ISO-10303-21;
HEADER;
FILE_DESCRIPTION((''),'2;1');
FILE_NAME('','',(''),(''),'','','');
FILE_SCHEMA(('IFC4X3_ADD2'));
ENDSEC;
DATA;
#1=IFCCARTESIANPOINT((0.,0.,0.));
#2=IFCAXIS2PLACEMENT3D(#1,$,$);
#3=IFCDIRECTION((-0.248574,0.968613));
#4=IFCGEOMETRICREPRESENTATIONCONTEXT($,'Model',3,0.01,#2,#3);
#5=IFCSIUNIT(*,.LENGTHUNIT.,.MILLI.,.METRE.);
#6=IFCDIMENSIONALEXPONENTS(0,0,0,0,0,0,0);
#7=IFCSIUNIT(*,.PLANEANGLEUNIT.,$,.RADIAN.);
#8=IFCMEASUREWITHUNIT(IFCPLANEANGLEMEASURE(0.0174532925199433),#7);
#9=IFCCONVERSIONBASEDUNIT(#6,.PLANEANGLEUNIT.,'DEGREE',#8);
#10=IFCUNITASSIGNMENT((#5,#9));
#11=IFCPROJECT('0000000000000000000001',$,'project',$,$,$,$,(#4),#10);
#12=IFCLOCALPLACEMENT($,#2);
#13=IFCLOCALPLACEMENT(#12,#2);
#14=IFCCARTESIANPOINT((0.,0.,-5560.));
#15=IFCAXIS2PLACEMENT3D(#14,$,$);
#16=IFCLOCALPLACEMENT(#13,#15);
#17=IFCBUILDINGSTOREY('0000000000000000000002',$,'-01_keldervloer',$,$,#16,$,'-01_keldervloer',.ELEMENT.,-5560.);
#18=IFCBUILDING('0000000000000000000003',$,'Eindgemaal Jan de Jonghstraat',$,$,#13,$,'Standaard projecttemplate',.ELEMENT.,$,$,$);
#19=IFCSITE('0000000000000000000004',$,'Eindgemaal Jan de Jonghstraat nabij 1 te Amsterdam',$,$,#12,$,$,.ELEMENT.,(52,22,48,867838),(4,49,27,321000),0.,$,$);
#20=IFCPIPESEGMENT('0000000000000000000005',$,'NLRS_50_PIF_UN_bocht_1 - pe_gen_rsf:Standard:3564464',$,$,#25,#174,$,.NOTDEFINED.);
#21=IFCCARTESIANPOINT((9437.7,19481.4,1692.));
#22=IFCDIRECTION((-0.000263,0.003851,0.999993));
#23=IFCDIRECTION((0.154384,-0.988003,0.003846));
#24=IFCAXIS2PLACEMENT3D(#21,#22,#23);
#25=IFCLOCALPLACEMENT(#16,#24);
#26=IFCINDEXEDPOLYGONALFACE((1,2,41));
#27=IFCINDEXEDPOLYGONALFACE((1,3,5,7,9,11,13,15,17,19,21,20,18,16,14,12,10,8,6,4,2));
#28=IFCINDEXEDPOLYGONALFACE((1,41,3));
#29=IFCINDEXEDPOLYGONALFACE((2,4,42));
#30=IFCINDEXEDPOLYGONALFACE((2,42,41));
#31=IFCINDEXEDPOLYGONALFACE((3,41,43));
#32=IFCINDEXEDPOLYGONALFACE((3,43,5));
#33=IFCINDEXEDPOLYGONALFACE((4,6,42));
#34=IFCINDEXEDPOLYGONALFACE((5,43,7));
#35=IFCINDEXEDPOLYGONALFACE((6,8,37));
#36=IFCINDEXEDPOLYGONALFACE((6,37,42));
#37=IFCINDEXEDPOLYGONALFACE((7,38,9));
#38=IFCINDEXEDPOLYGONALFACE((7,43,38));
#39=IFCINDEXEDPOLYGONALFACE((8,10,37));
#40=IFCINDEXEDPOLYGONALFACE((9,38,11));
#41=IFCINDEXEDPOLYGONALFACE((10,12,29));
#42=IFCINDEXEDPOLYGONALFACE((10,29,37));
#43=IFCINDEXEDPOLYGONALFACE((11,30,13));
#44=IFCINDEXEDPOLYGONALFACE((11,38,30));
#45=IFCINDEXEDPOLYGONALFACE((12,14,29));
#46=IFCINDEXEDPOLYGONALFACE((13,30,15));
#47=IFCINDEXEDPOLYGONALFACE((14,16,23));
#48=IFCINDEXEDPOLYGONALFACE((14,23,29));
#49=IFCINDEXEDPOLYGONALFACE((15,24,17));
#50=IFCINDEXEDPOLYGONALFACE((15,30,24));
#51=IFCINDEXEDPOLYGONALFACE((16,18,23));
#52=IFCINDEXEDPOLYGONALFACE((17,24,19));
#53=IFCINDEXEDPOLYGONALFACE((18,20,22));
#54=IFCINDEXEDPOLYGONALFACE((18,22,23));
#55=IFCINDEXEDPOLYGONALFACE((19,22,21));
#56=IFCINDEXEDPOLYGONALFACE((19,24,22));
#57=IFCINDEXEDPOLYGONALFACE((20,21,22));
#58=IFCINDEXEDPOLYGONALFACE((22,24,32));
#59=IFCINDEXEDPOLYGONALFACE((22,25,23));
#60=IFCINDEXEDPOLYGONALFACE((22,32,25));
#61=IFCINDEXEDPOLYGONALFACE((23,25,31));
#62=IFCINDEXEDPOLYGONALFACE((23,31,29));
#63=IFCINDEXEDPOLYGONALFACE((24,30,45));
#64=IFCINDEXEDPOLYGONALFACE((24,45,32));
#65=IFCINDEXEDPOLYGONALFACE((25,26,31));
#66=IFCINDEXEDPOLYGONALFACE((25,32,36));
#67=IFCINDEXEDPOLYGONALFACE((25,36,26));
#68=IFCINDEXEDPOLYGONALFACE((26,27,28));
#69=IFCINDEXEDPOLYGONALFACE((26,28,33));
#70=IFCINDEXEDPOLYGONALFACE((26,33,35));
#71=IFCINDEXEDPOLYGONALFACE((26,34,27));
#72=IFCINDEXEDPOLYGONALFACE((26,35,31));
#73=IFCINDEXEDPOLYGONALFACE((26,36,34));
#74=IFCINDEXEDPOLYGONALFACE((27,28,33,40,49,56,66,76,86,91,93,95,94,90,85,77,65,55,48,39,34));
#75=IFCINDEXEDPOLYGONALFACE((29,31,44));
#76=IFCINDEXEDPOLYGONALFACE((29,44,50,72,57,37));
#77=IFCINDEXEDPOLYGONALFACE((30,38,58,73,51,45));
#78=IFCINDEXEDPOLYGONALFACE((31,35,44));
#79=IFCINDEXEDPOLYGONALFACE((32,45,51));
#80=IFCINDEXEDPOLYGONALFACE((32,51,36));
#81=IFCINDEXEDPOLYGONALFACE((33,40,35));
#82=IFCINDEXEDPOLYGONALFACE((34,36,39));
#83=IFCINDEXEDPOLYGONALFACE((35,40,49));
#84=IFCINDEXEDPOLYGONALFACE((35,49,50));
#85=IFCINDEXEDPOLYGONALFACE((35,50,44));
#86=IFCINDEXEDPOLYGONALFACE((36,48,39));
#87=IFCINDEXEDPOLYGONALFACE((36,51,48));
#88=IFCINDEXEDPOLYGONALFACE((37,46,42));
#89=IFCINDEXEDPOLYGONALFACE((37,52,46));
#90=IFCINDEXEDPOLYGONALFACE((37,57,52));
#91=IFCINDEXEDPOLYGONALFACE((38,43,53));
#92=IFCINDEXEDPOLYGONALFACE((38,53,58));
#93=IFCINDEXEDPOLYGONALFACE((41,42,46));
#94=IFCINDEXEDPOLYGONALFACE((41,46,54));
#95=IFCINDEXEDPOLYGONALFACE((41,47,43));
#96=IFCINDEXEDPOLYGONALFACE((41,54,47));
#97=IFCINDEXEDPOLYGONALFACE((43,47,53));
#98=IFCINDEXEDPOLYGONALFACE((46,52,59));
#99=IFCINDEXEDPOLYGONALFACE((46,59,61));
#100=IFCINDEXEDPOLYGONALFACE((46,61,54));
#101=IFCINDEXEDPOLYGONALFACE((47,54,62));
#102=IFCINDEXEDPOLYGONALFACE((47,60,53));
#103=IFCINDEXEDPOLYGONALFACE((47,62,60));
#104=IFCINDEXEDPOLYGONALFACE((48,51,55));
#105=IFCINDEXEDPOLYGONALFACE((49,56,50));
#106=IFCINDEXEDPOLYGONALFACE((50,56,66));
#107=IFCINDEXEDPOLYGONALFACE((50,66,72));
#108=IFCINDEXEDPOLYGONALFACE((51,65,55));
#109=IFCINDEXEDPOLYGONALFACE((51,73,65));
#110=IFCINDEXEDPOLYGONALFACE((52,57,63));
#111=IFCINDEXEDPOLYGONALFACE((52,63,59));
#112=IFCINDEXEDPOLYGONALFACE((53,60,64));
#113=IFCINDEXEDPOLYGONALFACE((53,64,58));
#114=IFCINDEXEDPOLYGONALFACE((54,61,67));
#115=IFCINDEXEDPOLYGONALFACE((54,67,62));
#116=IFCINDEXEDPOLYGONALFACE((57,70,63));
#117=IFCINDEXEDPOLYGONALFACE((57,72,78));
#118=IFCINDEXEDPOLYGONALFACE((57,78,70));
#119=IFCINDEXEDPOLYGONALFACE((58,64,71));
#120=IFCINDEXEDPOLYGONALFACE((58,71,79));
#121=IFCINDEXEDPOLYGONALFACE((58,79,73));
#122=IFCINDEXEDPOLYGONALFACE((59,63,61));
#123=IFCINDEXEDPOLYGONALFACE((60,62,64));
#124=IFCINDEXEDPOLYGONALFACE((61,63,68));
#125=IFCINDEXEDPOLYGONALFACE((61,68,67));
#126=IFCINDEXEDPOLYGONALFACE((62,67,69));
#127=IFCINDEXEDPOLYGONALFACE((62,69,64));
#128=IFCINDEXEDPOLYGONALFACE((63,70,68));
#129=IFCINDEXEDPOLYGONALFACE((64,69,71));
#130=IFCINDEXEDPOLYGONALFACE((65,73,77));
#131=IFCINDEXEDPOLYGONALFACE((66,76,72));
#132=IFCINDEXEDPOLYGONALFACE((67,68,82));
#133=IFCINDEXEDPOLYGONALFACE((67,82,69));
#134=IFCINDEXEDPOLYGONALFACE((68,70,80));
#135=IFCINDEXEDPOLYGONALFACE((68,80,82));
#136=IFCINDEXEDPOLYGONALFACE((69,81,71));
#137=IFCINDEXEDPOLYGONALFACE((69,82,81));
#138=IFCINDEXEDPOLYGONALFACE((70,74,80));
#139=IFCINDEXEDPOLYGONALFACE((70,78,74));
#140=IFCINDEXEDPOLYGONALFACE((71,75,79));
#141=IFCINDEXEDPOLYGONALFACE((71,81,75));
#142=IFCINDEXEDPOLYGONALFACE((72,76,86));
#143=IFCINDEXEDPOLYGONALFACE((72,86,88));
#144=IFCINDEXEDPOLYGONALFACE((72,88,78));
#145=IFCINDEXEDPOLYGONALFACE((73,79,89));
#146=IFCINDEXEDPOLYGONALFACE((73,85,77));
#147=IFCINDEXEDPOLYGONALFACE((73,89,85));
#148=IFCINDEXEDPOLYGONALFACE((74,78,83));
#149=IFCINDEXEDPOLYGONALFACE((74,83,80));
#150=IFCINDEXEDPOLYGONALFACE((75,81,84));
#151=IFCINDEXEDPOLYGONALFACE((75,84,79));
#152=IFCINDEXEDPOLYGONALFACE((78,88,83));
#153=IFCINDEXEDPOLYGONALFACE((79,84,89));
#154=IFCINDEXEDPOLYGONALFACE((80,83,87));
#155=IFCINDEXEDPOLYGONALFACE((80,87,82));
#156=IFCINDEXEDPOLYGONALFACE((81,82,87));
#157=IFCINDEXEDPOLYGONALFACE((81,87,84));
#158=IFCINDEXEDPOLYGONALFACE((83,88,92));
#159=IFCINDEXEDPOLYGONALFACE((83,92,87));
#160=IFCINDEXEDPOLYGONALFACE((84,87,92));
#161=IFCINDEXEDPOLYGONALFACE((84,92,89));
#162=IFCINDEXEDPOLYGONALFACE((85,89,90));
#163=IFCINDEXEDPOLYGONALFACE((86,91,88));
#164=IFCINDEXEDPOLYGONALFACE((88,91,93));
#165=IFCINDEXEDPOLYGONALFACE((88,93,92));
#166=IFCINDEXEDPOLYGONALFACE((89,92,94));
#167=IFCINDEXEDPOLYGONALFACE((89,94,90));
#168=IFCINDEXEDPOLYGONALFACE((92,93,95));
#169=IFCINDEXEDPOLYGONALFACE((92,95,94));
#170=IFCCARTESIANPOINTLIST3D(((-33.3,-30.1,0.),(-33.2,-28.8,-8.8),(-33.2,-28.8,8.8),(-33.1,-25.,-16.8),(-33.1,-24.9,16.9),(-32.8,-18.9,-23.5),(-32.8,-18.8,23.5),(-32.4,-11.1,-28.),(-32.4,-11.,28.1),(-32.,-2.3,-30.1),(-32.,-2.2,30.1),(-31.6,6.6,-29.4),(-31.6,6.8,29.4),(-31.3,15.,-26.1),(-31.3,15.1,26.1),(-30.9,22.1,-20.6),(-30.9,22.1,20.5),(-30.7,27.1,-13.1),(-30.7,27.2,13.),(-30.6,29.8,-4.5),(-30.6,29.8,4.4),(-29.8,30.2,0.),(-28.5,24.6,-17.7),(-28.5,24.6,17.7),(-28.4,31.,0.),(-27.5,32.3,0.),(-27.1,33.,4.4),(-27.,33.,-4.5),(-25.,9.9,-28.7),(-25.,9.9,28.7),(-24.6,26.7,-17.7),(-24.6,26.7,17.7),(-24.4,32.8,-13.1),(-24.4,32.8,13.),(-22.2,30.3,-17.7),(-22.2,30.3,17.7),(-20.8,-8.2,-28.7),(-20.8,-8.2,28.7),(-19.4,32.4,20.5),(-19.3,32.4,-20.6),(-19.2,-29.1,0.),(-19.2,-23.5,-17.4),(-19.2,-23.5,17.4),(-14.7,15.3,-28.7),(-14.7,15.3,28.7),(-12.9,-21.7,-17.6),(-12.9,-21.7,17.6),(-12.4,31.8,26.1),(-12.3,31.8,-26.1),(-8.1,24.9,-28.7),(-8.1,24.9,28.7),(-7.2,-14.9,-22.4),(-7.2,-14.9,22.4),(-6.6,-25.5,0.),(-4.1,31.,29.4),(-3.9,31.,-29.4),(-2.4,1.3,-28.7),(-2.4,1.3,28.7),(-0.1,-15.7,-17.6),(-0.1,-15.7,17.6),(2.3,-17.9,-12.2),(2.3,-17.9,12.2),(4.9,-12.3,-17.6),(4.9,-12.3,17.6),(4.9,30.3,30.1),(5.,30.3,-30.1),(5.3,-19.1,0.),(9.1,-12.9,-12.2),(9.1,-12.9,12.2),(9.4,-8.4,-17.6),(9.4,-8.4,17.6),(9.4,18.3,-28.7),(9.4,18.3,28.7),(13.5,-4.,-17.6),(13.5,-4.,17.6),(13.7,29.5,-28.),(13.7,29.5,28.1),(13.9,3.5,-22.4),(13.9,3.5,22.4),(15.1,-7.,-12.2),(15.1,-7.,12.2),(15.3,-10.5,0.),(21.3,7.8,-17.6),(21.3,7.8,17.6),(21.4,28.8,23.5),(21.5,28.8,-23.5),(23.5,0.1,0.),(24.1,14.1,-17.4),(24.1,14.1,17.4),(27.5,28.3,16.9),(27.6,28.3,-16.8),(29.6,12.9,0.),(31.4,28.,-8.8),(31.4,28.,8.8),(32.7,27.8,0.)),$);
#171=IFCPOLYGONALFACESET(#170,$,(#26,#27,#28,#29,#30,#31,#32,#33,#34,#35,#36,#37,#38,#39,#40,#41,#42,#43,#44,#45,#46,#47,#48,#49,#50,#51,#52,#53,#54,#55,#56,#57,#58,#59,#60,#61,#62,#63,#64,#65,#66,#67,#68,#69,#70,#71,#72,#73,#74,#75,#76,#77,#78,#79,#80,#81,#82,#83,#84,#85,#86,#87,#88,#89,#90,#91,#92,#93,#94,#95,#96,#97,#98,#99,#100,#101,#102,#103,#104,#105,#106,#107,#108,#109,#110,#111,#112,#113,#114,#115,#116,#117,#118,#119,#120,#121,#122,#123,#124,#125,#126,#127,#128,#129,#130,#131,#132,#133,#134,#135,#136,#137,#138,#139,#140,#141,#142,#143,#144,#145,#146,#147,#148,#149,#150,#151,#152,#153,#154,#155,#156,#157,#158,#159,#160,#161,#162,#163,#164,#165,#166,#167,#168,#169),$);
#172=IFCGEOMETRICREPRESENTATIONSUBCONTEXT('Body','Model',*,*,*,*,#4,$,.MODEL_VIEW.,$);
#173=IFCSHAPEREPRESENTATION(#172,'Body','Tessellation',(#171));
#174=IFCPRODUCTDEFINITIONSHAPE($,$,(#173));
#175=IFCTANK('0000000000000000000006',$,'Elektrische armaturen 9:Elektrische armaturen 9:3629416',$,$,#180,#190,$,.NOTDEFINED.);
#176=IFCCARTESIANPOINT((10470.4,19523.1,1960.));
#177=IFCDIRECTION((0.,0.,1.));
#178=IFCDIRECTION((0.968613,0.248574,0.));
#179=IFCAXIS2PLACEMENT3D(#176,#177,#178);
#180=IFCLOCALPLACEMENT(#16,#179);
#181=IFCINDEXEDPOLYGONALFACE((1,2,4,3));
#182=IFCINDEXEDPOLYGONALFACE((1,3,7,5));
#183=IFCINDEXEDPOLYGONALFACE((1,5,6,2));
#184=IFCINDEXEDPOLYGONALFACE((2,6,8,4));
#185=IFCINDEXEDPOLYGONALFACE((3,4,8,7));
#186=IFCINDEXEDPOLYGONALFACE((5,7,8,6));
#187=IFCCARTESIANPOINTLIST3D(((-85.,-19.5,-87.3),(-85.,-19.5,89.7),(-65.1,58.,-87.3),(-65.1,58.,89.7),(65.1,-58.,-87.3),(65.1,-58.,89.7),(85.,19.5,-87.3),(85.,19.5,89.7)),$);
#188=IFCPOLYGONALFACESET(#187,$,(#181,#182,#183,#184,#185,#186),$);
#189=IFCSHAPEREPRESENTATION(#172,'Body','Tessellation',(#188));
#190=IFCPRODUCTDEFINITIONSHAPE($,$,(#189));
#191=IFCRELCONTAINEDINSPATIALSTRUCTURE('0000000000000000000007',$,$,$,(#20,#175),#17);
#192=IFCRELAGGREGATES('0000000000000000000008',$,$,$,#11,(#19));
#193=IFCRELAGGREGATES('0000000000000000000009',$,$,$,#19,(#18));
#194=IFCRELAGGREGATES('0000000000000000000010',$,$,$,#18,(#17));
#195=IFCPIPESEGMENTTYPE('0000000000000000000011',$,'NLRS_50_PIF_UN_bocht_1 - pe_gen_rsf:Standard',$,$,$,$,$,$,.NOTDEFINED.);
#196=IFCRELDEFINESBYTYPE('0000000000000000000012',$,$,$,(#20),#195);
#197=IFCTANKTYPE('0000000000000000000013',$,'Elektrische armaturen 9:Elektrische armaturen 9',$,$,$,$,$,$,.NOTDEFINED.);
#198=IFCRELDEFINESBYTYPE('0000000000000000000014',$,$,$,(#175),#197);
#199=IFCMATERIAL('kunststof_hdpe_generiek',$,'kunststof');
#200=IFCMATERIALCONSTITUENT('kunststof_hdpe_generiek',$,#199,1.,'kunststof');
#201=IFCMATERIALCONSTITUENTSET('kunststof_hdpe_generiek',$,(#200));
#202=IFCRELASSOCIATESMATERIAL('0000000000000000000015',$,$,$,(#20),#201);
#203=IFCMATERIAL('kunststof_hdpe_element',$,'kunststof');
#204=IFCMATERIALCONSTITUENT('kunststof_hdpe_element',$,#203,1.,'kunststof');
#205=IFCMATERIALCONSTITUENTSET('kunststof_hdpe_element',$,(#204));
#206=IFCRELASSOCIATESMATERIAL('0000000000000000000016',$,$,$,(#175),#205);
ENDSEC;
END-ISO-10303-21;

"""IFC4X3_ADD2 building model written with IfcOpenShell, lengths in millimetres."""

from ifc_helpers import new_model, entity, si_unit, converted_unit, direction, frame, origin, origin_2d_with_axis, place, context, subcontext, project, spatial, rectangle, extrude, source, transform, mapped, material, constituent, constituent_set, type_object, type_shapes, element, save


model = new_model("IFC4X3_ADD2")

# Units and contexts
model_context = context("Model", 3, precision=0.01, world=origin(), true_north=direction((-0.248574, 0.968613)))
body_context = subcontext(model_context, "Body", "Model", "MODEL_VIEW")
ifc_project = project(units=[si_unit("LENGTHUNIT", "METRE", prefix="MILLI"), converted_unit("PLANEANGLEUNIT", "DEGREE", entity("IfcPlaneAngleMeasure", 0.0174532925199433), si_unit("PLANEANGLEUNIT", "RADIAN"), dimensions=[0, 0, 0, 0, 0, 0, 0])], contexts=[model_context])

# Site, building, storey
site_placement = place(None, origin())
site = spatial("IfcSite", under=ifc_project, at=site_placement, Name="Eindgemaal Jan de Jonghstraat nabij 1 te Amsterdam", CompositionType="ELEMENT", RefLatitude=(52, 22, 48, 867838), RefLongitude=(4, 49, 27, 321000), RefElevation=0.0)
building_placement = place(site_placement, origin())
building = spatial("IfcBuilding", under=site, at=building_placement, Name="Eindgemaal Jan de Jonghstraat", LongName="Standaard projecttemplate", CompositionType="ELEMENT")
storey_placement = place(building_placement, frame((0.0, 0.0, -5560.0)))
storey = spatial("IfcBuildingStorey", under=building, at=storey_placement, Name="-01_keldervloer", LongName="-01_keldervloer", CompositionType="ELEMENT", Elevation=-5560.0)

# Pipe segment
ifc_material_1 = material(Name="kunststof_hdpe_generiek", Category="kunststof")
ifc_constituent_1 = constituent(ifc_material_1, Name="kunststof_hdpe_generiek", Category="kunststof", fraction=1.0)
ifc_constituent_set_1 = constituent_set(constituents=[ifc_constituent_1], Name="kunststof_hdpe_generiek")
pipe_segment_type_1 = type_object("IfcPipeSegmentType", Name="NLRS_50_PIF_UN_bocht_1 - pe_gen_rsf:Standard", PredefinedType="NOTDEFINED")
trimmed_curve_1 = entity("IfcTrimmedCurve", entity("IfcCircle", entity("IfcAxis2Placement2D", entity("IfcCartesianPoint", [-3.2, 0.0]), entity("IfcDirection", [0.08671, 0.996234])), 3.2), [entity("IfcParameterValue", 274.974347)], [entity("IfcParameterValue", 0.0)], True, "PARAMETER")
shared_shape_1 = source(origin(), body_context, "Body", "AdvancedSweptSolid", [
    entity("IfcSurfaceCurveSweptAreaSolid", entity("IfcCircleProfileDef", "AREA", None, entity("IfcAxis2Placement2D", entity("IfcCartesianPoint", [30.1, 0.0]), entity("IfcDirection", [1.0, 0.0])), 30.1), entity("IfcAxis2Placement3D", entity("IfcCartesianPoint", [-27.4, 33.1, 0.0]), entity("IfcDirection", [0.0, 0.0, -1.0]), entity("IfcDirection", [0.996234, -0.08671, 0.0])), trimmed_curve_1, entity("IfcParameterValue", 0.0), entity("IfcParameterValue", 85.025653), entity("IfcSurfaceOfLinearExtrusion", entity("IfcArbitraryOpenProfileDef", "CURVE", None, trimmed_curve_1), entity("IfcAxis2Placement3D", entity("IfcCartesianPoint", [0.0, 0.0, -304.8])), entity("IfcDirection", [0.0, 0.0, 1.0]), 1.0)),
])
type_shapes(pipe_segment_type_1, [shared_shape_1])
pipe_segment_1_placement = place(storey_placement, frame((9437.7, 19481.4, 1692.0), z_axis=(-0.000263, 0.003851, 0.999993), x_axis=(0.154384, -0.988003, 0.003846)))
element("IfcPipeSegment", 1, at=pipe_segment_1_placement, inside=storey, type_object=pipe_segment_type_1, material=ifc_constituent_set_1, Name="NLRS_50_PIF_UN_bocht_1 - pe_gen_rsf:Standard:3564464", PredefinedType="NOTDEFINED", context=body_context, shape_type="MappedRepresentation", body=[
    mapped(shared_shape_1, transform((0.0, 0.0, 0.0), scale=1.0)),
])

# Tank
ifc_material_2 = material(Name="kunststof_hdpe_element", Category="kunststof")
ifc_constituent_2 = constituent(ifc_material_2, Name="kunststof_hdpe_element", Category="kunststof", fraction=1.0)
ifc_constituent_set_2 = constituent_set(constituents=[ifc_constituent_2], Name="kunststof_hdpe_element")
tank_type = type_object("IfcTankType", Name="Elektrische armaturen 9:Elektrische armaturen 9", PredefinedType="NOTDEFINED")
shared_shape_2 = source(origin(), body_context, "Body", "SweptSolid", [
    extrude(rectangle(XDim=80.0, YDim=155.0, at=origin_2d_with_axis()), frame((0.0, 0.0, -87.3), z_axis=(0.0, 0.0, 1.0), x_axis=(0.248574, 0.968613, 0.0)), (0.0, 0.0, 1.0), 177.0),
])
type_shapes(tank_type, [shared_shape_2])
tank_placement = place(storey_placement, frame((10470.4, 19523.1, 1960.0), z_axis=(0.0, 0.0, 1.0), x_axis=(0.968613, 0.248574, 0.0)))
element("IfcTank", 2, at=tank_placement, inside=storey, type_object=tank_type, material=ifc_constituent_set_2, Name="Elektrische armaturen 9:Elektrische armaturen 9:3629416", PredefinedType="NOTDEFINED", context=body_context, shape_type="MappedRepresentation", body=[
    mapped(shared_shape_2, transform((0.0, 0.0, 0.0), scale=1.0)),
])

save(model, "model.ifc")
